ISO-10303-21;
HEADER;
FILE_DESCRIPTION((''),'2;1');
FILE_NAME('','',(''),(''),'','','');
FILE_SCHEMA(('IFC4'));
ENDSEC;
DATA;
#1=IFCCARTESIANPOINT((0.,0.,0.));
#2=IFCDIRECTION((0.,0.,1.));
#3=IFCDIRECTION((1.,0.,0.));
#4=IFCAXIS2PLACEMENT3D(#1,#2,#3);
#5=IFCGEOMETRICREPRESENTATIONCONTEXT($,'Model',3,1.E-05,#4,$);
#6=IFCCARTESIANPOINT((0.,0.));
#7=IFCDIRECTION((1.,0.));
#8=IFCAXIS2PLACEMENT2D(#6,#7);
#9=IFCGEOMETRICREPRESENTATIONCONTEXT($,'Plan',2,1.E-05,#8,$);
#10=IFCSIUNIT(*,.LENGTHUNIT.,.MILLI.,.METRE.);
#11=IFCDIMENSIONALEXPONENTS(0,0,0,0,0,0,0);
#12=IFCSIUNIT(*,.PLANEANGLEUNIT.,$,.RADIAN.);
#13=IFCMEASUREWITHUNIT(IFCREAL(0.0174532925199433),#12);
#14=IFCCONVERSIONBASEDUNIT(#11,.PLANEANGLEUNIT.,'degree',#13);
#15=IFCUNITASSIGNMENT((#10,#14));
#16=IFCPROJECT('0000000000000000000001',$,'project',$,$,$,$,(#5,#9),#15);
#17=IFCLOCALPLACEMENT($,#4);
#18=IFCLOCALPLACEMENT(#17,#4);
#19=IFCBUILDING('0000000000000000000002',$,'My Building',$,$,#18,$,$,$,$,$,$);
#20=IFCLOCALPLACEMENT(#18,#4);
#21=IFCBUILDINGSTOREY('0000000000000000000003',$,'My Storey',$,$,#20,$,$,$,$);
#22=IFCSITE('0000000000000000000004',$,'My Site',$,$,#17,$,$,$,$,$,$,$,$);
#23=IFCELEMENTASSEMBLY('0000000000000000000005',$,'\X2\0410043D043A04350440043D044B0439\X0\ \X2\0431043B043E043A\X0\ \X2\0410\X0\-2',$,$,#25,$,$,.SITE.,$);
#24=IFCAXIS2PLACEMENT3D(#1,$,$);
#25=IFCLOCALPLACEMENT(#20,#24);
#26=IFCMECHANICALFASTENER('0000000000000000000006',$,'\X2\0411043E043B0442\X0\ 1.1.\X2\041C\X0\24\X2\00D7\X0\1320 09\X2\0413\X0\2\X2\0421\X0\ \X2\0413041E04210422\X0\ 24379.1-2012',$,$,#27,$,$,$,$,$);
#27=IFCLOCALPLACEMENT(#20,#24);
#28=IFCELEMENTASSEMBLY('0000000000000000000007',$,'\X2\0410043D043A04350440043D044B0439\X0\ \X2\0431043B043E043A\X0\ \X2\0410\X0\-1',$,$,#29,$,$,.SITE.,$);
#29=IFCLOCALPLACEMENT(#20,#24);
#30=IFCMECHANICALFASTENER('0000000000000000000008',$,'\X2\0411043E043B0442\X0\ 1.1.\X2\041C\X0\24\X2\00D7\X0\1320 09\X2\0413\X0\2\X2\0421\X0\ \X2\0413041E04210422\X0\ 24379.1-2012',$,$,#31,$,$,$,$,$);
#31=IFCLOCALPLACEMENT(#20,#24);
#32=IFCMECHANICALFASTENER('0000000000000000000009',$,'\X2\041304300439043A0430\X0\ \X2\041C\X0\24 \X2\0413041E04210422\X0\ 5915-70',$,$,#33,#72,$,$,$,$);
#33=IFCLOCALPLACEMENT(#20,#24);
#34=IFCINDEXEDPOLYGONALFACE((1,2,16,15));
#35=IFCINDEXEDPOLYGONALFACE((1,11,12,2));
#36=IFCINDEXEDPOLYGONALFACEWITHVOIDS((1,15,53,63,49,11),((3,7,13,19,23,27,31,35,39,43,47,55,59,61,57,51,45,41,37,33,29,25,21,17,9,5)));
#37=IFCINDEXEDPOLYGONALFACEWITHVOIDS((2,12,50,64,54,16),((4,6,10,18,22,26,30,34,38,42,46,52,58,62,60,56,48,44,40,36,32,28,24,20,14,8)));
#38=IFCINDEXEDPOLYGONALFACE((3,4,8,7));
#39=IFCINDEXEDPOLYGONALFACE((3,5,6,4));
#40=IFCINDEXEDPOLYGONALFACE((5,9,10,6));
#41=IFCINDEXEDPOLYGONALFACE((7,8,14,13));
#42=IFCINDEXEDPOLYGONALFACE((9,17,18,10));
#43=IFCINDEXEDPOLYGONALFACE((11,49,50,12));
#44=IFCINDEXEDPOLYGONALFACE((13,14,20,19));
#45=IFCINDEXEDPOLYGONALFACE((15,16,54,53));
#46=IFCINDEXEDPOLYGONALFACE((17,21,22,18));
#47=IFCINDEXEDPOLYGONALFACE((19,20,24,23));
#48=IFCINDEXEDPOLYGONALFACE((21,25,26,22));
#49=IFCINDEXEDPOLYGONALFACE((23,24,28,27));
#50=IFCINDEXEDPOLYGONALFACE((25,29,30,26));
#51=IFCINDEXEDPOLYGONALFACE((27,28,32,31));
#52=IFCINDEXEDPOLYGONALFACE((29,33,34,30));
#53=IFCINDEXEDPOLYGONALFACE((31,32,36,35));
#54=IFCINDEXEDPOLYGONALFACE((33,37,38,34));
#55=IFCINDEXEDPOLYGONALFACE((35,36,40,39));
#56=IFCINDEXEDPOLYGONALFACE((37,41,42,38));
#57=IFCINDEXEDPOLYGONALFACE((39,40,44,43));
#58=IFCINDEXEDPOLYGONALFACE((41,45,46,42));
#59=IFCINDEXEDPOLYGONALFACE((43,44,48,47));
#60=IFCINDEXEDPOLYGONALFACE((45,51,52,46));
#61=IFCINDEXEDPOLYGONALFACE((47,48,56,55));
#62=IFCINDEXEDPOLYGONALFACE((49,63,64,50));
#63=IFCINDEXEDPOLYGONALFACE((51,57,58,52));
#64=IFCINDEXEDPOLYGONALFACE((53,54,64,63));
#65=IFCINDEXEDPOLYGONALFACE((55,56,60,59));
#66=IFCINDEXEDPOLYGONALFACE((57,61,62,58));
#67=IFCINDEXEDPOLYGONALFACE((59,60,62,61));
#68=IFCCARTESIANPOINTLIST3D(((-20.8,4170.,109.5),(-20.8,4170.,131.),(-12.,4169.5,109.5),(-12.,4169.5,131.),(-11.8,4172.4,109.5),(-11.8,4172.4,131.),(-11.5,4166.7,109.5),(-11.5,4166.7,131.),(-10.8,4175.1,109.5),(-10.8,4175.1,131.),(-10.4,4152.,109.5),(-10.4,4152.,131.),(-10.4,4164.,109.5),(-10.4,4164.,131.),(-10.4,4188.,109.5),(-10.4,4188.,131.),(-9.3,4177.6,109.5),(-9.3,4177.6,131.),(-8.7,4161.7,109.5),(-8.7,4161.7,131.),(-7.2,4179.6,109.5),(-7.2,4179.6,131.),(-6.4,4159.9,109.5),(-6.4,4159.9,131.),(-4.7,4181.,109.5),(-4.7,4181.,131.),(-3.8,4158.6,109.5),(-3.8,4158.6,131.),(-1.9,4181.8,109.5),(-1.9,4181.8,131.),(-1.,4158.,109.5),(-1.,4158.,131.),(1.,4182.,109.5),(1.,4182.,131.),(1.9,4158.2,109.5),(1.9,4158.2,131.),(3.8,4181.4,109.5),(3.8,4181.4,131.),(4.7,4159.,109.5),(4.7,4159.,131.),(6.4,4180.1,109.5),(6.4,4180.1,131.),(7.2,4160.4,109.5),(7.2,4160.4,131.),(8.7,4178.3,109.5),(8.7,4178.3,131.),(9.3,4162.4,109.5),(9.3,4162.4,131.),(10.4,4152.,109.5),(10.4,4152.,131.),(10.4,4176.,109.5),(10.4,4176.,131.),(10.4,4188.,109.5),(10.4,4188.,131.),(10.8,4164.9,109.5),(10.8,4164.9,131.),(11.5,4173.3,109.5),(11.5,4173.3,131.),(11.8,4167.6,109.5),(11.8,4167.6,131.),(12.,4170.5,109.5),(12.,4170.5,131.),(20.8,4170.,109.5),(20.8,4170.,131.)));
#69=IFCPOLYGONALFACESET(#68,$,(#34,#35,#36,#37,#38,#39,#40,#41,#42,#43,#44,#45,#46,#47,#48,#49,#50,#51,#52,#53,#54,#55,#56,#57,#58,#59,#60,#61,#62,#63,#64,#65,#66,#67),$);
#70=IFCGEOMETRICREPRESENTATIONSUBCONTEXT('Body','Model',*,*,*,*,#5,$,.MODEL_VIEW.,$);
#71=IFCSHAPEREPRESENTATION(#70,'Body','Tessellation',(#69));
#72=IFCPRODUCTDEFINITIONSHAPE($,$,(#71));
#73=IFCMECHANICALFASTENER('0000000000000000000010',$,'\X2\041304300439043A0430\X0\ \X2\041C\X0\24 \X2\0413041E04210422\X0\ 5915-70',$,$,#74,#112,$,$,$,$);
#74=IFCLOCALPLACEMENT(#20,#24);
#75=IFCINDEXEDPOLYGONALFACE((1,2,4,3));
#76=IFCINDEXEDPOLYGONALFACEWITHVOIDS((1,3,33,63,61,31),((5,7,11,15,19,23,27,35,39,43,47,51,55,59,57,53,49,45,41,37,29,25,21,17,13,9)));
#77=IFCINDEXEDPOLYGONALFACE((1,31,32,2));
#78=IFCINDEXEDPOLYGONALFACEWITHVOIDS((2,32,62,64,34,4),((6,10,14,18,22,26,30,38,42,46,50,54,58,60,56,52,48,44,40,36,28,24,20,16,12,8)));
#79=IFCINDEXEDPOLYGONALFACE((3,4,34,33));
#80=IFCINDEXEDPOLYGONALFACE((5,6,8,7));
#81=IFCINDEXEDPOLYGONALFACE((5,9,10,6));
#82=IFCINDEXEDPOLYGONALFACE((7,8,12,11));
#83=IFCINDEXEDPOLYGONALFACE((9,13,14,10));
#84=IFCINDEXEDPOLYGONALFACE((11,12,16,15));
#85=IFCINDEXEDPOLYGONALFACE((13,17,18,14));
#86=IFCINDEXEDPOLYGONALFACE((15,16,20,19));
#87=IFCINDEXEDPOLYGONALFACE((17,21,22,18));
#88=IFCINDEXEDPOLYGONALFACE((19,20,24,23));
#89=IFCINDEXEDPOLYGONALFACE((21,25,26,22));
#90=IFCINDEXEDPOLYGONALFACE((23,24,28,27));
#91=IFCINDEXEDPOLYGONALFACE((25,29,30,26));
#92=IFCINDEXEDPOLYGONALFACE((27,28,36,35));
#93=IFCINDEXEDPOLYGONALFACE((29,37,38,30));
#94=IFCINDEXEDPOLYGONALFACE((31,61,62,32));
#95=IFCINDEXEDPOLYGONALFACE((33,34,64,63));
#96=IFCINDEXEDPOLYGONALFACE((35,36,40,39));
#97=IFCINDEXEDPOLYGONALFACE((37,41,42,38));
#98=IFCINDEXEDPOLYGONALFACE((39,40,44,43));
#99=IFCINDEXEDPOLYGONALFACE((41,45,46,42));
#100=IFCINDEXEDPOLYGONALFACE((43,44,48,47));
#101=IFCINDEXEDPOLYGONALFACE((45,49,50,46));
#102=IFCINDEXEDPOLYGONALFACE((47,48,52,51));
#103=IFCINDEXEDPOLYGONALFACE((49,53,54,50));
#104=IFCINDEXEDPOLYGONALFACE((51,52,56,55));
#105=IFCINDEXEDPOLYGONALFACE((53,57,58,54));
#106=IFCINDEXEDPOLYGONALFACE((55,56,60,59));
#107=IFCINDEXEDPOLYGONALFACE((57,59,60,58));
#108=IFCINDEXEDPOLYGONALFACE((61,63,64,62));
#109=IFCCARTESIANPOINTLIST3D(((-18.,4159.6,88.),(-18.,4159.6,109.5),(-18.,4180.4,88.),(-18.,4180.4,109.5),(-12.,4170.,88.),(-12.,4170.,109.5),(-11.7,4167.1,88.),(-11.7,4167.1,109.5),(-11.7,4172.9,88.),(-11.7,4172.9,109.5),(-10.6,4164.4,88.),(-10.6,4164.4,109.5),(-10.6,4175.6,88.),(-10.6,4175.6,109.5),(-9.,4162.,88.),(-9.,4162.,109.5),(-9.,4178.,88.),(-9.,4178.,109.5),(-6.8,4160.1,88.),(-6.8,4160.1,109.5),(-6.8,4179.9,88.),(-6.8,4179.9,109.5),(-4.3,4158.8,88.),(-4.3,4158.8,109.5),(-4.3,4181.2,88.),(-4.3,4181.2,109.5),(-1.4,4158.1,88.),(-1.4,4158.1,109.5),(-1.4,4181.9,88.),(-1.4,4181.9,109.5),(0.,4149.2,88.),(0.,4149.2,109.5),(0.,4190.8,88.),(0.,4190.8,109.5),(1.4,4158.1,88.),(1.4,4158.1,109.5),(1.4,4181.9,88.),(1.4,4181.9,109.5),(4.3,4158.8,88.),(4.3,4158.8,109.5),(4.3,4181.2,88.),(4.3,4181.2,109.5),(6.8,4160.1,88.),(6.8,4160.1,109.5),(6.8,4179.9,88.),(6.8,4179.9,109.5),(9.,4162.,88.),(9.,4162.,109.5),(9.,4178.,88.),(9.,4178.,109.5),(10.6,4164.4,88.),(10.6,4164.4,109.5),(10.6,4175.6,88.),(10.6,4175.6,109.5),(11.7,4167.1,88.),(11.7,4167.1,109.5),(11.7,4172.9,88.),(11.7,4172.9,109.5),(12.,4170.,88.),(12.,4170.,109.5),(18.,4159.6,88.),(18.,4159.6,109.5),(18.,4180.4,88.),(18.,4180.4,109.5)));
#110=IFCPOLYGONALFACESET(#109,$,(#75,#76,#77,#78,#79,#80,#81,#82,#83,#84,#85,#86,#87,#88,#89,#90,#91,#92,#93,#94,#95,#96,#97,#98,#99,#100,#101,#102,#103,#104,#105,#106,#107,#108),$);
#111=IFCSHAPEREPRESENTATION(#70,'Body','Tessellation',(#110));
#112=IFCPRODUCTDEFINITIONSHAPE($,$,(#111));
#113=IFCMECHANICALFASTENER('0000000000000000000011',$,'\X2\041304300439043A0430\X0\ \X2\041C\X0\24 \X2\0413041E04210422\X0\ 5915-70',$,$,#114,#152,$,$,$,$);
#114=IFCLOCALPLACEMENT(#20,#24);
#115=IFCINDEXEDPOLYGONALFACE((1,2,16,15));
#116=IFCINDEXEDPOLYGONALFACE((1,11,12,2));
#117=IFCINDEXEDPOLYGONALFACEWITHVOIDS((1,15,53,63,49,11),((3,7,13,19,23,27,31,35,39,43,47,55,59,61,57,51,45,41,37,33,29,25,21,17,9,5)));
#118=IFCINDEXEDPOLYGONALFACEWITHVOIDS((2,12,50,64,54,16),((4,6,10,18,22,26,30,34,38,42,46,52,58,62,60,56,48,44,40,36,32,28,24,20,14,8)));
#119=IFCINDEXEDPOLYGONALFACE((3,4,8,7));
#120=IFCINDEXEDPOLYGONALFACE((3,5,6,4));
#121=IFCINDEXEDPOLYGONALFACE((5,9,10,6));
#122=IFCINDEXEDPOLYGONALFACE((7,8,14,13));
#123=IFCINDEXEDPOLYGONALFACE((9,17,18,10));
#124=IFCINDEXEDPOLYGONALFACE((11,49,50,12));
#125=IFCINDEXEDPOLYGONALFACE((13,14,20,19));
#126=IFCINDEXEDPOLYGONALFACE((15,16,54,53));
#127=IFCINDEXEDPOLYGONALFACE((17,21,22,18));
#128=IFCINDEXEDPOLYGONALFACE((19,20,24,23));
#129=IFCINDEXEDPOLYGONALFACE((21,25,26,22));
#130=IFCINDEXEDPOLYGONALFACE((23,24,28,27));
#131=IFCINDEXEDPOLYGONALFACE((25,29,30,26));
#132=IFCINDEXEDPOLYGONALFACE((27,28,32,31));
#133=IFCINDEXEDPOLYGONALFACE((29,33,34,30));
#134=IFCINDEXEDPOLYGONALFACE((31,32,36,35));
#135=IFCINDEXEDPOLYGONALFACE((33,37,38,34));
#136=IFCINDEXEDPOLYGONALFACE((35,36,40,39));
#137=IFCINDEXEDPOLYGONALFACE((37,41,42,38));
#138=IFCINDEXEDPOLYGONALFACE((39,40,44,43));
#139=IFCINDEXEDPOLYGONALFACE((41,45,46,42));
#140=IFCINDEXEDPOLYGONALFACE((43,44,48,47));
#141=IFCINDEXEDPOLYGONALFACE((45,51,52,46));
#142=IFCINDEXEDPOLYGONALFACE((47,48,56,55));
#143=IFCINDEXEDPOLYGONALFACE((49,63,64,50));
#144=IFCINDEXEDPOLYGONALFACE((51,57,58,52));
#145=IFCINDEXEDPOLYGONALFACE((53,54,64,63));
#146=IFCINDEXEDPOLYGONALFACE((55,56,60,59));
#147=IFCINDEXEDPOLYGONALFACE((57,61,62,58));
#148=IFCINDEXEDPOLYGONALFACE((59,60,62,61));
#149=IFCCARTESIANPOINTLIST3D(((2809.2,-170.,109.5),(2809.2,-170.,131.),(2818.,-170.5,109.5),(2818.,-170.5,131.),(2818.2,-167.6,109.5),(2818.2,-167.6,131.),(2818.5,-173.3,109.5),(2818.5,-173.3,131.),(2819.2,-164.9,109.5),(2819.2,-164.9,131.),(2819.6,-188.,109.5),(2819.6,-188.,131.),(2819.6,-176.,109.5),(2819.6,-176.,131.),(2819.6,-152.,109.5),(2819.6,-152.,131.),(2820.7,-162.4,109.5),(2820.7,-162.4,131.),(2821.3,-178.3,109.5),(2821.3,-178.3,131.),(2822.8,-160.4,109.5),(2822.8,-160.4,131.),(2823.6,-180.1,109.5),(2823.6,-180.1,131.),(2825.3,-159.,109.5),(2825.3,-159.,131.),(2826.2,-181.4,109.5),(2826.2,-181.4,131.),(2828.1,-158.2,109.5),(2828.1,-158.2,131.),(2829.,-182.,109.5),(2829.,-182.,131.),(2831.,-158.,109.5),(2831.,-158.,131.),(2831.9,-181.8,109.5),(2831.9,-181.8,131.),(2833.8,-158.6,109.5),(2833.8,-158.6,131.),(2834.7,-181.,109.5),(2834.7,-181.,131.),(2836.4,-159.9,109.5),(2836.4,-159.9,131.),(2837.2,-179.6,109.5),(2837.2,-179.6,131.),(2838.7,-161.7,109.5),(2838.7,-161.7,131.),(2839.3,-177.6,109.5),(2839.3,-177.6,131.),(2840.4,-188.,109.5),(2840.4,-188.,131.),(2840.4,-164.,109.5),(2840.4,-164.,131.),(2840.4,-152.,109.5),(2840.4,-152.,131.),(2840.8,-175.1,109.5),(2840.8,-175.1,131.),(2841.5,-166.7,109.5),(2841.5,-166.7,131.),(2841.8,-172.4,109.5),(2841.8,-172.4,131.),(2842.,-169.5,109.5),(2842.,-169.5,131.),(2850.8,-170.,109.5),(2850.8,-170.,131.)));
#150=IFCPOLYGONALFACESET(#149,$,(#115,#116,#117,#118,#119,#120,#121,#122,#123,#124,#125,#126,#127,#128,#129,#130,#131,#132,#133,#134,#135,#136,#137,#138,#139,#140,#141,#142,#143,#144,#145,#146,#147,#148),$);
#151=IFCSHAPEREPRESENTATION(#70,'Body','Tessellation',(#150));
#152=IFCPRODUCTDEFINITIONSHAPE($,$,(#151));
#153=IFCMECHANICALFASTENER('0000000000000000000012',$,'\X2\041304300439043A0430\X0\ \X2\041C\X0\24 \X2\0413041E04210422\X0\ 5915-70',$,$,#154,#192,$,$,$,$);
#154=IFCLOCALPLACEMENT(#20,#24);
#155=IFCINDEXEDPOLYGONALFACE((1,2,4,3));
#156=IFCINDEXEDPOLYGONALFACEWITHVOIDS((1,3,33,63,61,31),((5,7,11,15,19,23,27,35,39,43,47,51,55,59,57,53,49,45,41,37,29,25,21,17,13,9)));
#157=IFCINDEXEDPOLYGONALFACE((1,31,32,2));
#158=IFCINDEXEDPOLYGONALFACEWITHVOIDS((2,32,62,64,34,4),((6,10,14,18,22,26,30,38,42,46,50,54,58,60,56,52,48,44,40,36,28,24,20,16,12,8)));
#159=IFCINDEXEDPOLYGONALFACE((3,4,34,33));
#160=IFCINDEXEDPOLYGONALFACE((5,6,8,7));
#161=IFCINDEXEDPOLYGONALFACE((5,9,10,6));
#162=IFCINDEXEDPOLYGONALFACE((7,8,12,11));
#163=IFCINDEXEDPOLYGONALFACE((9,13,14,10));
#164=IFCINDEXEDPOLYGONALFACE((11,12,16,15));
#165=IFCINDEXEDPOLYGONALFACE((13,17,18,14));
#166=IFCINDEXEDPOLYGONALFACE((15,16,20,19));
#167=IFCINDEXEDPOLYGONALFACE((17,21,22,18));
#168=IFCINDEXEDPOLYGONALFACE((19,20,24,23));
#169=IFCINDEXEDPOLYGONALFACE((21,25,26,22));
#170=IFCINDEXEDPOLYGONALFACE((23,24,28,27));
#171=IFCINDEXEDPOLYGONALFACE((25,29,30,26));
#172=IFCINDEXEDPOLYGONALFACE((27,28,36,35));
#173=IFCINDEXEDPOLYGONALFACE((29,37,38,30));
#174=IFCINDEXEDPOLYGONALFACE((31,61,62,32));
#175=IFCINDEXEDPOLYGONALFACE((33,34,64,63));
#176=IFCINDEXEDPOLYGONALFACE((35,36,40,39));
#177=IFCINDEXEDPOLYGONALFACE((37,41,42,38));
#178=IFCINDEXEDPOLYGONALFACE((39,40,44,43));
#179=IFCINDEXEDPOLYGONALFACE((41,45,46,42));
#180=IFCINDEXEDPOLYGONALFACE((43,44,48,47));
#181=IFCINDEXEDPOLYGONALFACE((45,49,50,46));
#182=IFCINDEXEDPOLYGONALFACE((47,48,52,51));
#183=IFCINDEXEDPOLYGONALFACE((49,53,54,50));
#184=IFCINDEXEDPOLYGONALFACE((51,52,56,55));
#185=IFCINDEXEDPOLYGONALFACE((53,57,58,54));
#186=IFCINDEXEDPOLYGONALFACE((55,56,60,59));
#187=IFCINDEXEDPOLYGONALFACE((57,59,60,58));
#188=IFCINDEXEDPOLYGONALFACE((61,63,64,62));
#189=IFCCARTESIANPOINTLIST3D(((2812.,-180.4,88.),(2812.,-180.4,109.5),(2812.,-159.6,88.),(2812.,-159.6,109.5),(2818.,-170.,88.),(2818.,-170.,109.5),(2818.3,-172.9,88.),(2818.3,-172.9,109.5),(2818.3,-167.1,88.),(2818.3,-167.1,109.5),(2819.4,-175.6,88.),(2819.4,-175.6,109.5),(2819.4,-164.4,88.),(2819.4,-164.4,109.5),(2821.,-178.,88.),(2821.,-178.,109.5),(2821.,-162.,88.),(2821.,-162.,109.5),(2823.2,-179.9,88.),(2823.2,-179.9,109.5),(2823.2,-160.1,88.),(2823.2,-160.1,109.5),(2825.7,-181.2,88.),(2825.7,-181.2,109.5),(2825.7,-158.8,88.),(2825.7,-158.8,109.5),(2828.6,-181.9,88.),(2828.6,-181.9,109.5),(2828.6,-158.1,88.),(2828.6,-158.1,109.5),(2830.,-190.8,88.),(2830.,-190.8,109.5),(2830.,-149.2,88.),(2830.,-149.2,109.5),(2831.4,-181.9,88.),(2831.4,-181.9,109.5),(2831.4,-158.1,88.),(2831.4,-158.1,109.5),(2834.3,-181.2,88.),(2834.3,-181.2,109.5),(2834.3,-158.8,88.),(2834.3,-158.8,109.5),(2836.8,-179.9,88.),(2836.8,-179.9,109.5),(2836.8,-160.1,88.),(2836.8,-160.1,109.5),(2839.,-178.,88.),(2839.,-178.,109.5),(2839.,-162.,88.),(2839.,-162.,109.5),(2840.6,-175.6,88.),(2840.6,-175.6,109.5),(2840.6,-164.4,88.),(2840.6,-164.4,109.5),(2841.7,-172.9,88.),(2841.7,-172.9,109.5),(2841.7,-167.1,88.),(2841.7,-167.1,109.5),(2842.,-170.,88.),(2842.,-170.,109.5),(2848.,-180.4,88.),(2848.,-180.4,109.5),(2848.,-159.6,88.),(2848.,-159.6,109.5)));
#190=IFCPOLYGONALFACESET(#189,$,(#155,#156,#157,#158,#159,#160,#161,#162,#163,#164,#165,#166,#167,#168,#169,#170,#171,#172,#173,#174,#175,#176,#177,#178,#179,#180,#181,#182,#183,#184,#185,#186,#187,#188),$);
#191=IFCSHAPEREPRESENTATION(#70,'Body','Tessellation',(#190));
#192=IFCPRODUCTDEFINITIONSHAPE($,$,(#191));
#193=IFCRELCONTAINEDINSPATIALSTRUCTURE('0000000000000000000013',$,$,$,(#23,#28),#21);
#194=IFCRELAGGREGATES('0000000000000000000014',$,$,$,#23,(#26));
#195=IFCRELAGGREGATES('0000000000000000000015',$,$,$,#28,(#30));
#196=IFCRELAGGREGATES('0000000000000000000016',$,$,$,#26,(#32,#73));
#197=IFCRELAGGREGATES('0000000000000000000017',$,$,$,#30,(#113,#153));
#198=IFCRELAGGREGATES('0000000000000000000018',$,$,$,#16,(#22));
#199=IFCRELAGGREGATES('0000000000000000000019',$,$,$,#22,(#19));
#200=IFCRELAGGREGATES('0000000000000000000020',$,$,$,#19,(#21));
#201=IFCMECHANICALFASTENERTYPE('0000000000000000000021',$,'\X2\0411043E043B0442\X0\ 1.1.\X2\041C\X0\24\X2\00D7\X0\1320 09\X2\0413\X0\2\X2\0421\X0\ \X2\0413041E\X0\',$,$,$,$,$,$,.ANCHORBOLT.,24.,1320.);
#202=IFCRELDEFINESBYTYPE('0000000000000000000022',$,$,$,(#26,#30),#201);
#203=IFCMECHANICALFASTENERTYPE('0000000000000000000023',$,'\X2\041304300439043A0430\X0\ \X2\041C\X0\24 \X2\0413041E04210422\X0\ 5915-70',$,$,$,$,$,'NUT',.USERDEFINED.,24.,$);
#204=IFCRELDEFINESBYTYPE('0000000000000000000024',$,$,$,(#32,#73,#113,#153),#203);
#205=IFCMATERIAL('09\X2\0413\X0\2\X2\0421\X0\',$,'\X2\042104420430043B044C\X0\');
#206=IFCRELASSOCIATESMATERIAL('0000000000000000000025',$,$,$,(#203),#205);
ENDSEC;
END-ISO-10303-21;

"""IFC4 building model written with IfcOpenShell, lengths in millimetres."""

from ifc_helpers import new_model, entity, si_unit, converted_unit, frame, origin_with_axes, origin_2d_with_axis, place, context, subcontext, project, spatial, polyline, outline, extrude, source, transform, mapped, material, type_object, type_shapes, element, aggregate, save


model = new_model("IFC4")

# Units and contexts
model_context = context("Model", 3, precision=1e-05, world=origin_with_axes())
plan_context = context("Plan", 2, precision=1e-05, world=origin_2d_with_axis())
body_context = subcontext(model_context, "Body", "Model", "MODEL_VIEW")
ifc_project = project(units=[si_unit("LENGTHUNIT", "METRE", prefix="MILLI"), converted_unit("PLANEANGLEUNIT", "degree", entity("IfcReal", 0.0174532925199433), si_unit("PLANEANGLEUNIT", "RADIAN"), dimensions=[0, 0, 0, 0, 0, 0, 0])], contexts=[model_context, plan_context])

# Site, building, storey
site_placement = place(None, origin_with_axes())
site = spatial("IfcSite", under=ifc_project, at=site_placement, Name="My Site")
building_placement = place(site_placement, origin_with_axes())
building = spatial("IfcBuilding", under=site, at=building_placement, Name="My Building")
storey_placement = place(building_placement, origin_with_axes())
storey = spatial("IfcBuildingStorey", under=building, at=storey_placement, Name="My Storey")

# Shared definitions
placement_1 = place(storey_placement, frame((0.0, 4000.0, 0.0), z_axis=(0.0, 0.0, 1.0), x_axis=(1.0, 0.0, 0.0)))

# Element assemblies, mechanical fasteners
ifc_material_1 = material(Name="09Г2С", Category="Сталь")
mechanical_fastener_type_1 = type_object("IfcMechanicalFastenerType", Name="Болт 1.1.М24×1320 09Г2С ГО", NominalDiameter=24.0, NominalLength=1320.0, PredefinedType="ANCHORBOLT")
assembly_1 = element("IfcElementAssembly", 1, at=placement_1, inside=storey, Name="Анкерный блок А-2", AssemblyPlace="SITE")
mechanical_fastener_1_placement = place(placement_1, frame((0.0, 170.0, 0.0), z_axis=(0.0, 0.0, 1.0), x_axis=(-1.0, 0.0, 0.0)))
mechanical_fastener_1 = element("IfcMechanicalFastener", 2, at=mechanical_fastener_1_placement, type_object=mechanical_fastener_type_1, Name="Болт 1.1.М24×1320 09Г2С ГОСТ 24379.1-2012")
aggregate(assembly_1, [mechanical_fastener_1])
assembly_2_placement = place(storey_placement, frame((3000.0, 0.0, 0.0), z_axis=(0.0, 0.0, 1.0), x_axis=(1.0, 0.0, 0.0)))
assembly_2 = element("IfcElementAssembly", 3, at=assembly_2_placement, inside=storey, Name="Анкерный блок А-1", AssemblyPlace="SITE")
mechanical_fastener_2_placement = place(assembly_2_placement, frame((-170.0, -170.0, 0.0), z_axis=(0.0, 0.0, 1.0), x_axis=(1.0, 0.0, 0.0)))
mechanical_fastener_2 = element("IfcMechanicalFastener", 4, at=mechanical_fastener_2_placement, type_object=mechanical_fastener_type_1, Name="Болт 1.1.М24×1320 09Г2С ГОСТ 24379.1-2012")
aggregate(assembly_2, [mechanical_fastener_2])

# Mechanical fasteners
mechanical_fastener_type_2 = type_object("IfcMechanicalFastenerType", Name="Гайка М24 ГОСТ 5915-70", ElementType="NUT", NominalDiameter=24.0, PredefinedType="USERDEFINED", material=ifc_material_1)
shared_shape_1 = source(origin_with_axes(), body_context, "Body", "SweptSolid", [
    extrude(outline(polyline([(-10.4, -18.0), (10.4, -18.0), (20.8, 0.0), (10.4, 18.0), (-10.4, 18.0), (-20.8, 0.0), (-10.4, -18.0)]), holes=[polyline([(-8.0, 9.0), (-5.6, 10.6), (-2.9, 11.7), (0.0, 12.0), (2.9, 11.7), (5.6, 10.6), (8.0, 9.0), (9.9, 6.8), (11.2, 4.3), (11.9, 1.4), (11.9, -1.4), (11.2, -4.3), (9.9, -6.8), (8.0, -9.0), (5.6, -10.6), (2.9, -11.7), (0.0, -12.0), (-2.9, -11.7), (-5.6, -10.6), (-8.0, -9.0), (-9.9, -6.8), (-11.2, -4.3), (-11.9, -1.4), (-11.9, 1.4), (-11.2, 4.3), (-9.9, 6.8), (-8.0, 9.0)])]), frame((0.0, 0.0, 0.0), z_axis=(0.0, 0.0, 1.0), x_axis=(0.0, 1.0, 0.0)), (0.0, 0.0, 1.0), 21.5),
])
type_shapes(mechanical_fastener_type_2, [shared_shape_1])
mechanical_fastener_3_placement = place(mechanical_fastener_1_placement, frame((0.0, 0.0, 109.5), z_axis=(0.0, 0.0, 1.0), x_axis=(0.866025, 0.5, 0.0)))
mechanical_fastener_3 = element("IfcMechanicalFastener", 5, at=mechanical_fastener_3_placement, type_object=mechanical_fastener_type_2, Name="Гайка М24 ГОСТ 5915-70", context=body_context, shape_type="MappedRepresentation", body=[
    mapped(shared_shape_1, transform((0.0, 0.0, 0.0), x_axis=(1.0, 0.0, 0.0), y_axis=(0.0, 1.0, 0.0), z_axis=(0.0, 0.0, 1.0), scale=1.0)),
])
mechanical_fastener_4_placement = place(mechanical_fastener_1_placement, frame((0.0, 0.0, 88.0), z_axis=(0.0, 0.0, 1.0), x_axis=(1.0, 0.0, 0.0)))
mechanical_fastener_4 = element("IfcMechanicalFastener", 6, at=mechanical_fastener_4_placement, type_object=mechanical_fastener_type_2, Name="Гайка М24 ГОСТ 5915-70", context=body_context, shape_type="MappedRepresentation", body=[
    mapped(shared_shape_1, transform((0.0, 0.0, 0.0), x_axis=(1.0, 0.0, 0.0), y_axis=(0.0, 1.0, 0.0), z_axis=(0.0, 0.0, 1.0), scale=1.0)),
])
mechanical_fastener_5_placement = place(mechanical_fastener_2_placement, frame((0.0, 0.0, 109.5), z_axis=(0.0, 0.0, 1.0), x_axis=(0.866025, 0.5, 0.0)))
mechanical_fastener_5 = element("IfcMechanicalFastener", 7, at=mechanical_fastener_5_placement, type_object=mechanical_fastener_type_2, Name="Гайка М24 ГОСТ 5915-70", context=body_context, shape_type="MappedRepresentation", body=[
    mapped(shared_shape_1, transform((0.0, 0.0, 0.0), x_axis=(1.0, 0.0, 0.0), y_axis=(0.0, 1.0, 0.0), z_axis=(0.0, 0.0, 1.0), scale=1.0)),
])
mechanical_fastener_6_placement = place(mechanical_fastener_2_placement, frame((0.0, 0.0, 88.0), z_axis=(0.0, 0.0, 1.0), x_axis=(1.0, 0.0, 0.0)))
mechanical_fastener_6 = element("IfcMechanicalFastener", 8, at=mechanical_fastener_6_placement, type_object=mechanical_fastener_type_2, Name="Гайка М24 ГОСТ 5915-70", context=body_context, shape_type="MappedRepresentation", body=[
    mapped(shared_shape_1, transform((0.0, 0.0, 0.0), x_axis=(1.0, 0.0, 0.0), y_axis=(0.0, 1.0, 0.0), z_axis=(0.0, 0.0, 1.0), scale=1.0)),
])
aggregate(mechanical_fastener_1, [mechanical_fastener_3, mechanical_fastener_4])
aggregate(mechanical_fastener_2, [mechanical_fastener_5, mechanical_fastener_6])

save(model, "model.ifc")
